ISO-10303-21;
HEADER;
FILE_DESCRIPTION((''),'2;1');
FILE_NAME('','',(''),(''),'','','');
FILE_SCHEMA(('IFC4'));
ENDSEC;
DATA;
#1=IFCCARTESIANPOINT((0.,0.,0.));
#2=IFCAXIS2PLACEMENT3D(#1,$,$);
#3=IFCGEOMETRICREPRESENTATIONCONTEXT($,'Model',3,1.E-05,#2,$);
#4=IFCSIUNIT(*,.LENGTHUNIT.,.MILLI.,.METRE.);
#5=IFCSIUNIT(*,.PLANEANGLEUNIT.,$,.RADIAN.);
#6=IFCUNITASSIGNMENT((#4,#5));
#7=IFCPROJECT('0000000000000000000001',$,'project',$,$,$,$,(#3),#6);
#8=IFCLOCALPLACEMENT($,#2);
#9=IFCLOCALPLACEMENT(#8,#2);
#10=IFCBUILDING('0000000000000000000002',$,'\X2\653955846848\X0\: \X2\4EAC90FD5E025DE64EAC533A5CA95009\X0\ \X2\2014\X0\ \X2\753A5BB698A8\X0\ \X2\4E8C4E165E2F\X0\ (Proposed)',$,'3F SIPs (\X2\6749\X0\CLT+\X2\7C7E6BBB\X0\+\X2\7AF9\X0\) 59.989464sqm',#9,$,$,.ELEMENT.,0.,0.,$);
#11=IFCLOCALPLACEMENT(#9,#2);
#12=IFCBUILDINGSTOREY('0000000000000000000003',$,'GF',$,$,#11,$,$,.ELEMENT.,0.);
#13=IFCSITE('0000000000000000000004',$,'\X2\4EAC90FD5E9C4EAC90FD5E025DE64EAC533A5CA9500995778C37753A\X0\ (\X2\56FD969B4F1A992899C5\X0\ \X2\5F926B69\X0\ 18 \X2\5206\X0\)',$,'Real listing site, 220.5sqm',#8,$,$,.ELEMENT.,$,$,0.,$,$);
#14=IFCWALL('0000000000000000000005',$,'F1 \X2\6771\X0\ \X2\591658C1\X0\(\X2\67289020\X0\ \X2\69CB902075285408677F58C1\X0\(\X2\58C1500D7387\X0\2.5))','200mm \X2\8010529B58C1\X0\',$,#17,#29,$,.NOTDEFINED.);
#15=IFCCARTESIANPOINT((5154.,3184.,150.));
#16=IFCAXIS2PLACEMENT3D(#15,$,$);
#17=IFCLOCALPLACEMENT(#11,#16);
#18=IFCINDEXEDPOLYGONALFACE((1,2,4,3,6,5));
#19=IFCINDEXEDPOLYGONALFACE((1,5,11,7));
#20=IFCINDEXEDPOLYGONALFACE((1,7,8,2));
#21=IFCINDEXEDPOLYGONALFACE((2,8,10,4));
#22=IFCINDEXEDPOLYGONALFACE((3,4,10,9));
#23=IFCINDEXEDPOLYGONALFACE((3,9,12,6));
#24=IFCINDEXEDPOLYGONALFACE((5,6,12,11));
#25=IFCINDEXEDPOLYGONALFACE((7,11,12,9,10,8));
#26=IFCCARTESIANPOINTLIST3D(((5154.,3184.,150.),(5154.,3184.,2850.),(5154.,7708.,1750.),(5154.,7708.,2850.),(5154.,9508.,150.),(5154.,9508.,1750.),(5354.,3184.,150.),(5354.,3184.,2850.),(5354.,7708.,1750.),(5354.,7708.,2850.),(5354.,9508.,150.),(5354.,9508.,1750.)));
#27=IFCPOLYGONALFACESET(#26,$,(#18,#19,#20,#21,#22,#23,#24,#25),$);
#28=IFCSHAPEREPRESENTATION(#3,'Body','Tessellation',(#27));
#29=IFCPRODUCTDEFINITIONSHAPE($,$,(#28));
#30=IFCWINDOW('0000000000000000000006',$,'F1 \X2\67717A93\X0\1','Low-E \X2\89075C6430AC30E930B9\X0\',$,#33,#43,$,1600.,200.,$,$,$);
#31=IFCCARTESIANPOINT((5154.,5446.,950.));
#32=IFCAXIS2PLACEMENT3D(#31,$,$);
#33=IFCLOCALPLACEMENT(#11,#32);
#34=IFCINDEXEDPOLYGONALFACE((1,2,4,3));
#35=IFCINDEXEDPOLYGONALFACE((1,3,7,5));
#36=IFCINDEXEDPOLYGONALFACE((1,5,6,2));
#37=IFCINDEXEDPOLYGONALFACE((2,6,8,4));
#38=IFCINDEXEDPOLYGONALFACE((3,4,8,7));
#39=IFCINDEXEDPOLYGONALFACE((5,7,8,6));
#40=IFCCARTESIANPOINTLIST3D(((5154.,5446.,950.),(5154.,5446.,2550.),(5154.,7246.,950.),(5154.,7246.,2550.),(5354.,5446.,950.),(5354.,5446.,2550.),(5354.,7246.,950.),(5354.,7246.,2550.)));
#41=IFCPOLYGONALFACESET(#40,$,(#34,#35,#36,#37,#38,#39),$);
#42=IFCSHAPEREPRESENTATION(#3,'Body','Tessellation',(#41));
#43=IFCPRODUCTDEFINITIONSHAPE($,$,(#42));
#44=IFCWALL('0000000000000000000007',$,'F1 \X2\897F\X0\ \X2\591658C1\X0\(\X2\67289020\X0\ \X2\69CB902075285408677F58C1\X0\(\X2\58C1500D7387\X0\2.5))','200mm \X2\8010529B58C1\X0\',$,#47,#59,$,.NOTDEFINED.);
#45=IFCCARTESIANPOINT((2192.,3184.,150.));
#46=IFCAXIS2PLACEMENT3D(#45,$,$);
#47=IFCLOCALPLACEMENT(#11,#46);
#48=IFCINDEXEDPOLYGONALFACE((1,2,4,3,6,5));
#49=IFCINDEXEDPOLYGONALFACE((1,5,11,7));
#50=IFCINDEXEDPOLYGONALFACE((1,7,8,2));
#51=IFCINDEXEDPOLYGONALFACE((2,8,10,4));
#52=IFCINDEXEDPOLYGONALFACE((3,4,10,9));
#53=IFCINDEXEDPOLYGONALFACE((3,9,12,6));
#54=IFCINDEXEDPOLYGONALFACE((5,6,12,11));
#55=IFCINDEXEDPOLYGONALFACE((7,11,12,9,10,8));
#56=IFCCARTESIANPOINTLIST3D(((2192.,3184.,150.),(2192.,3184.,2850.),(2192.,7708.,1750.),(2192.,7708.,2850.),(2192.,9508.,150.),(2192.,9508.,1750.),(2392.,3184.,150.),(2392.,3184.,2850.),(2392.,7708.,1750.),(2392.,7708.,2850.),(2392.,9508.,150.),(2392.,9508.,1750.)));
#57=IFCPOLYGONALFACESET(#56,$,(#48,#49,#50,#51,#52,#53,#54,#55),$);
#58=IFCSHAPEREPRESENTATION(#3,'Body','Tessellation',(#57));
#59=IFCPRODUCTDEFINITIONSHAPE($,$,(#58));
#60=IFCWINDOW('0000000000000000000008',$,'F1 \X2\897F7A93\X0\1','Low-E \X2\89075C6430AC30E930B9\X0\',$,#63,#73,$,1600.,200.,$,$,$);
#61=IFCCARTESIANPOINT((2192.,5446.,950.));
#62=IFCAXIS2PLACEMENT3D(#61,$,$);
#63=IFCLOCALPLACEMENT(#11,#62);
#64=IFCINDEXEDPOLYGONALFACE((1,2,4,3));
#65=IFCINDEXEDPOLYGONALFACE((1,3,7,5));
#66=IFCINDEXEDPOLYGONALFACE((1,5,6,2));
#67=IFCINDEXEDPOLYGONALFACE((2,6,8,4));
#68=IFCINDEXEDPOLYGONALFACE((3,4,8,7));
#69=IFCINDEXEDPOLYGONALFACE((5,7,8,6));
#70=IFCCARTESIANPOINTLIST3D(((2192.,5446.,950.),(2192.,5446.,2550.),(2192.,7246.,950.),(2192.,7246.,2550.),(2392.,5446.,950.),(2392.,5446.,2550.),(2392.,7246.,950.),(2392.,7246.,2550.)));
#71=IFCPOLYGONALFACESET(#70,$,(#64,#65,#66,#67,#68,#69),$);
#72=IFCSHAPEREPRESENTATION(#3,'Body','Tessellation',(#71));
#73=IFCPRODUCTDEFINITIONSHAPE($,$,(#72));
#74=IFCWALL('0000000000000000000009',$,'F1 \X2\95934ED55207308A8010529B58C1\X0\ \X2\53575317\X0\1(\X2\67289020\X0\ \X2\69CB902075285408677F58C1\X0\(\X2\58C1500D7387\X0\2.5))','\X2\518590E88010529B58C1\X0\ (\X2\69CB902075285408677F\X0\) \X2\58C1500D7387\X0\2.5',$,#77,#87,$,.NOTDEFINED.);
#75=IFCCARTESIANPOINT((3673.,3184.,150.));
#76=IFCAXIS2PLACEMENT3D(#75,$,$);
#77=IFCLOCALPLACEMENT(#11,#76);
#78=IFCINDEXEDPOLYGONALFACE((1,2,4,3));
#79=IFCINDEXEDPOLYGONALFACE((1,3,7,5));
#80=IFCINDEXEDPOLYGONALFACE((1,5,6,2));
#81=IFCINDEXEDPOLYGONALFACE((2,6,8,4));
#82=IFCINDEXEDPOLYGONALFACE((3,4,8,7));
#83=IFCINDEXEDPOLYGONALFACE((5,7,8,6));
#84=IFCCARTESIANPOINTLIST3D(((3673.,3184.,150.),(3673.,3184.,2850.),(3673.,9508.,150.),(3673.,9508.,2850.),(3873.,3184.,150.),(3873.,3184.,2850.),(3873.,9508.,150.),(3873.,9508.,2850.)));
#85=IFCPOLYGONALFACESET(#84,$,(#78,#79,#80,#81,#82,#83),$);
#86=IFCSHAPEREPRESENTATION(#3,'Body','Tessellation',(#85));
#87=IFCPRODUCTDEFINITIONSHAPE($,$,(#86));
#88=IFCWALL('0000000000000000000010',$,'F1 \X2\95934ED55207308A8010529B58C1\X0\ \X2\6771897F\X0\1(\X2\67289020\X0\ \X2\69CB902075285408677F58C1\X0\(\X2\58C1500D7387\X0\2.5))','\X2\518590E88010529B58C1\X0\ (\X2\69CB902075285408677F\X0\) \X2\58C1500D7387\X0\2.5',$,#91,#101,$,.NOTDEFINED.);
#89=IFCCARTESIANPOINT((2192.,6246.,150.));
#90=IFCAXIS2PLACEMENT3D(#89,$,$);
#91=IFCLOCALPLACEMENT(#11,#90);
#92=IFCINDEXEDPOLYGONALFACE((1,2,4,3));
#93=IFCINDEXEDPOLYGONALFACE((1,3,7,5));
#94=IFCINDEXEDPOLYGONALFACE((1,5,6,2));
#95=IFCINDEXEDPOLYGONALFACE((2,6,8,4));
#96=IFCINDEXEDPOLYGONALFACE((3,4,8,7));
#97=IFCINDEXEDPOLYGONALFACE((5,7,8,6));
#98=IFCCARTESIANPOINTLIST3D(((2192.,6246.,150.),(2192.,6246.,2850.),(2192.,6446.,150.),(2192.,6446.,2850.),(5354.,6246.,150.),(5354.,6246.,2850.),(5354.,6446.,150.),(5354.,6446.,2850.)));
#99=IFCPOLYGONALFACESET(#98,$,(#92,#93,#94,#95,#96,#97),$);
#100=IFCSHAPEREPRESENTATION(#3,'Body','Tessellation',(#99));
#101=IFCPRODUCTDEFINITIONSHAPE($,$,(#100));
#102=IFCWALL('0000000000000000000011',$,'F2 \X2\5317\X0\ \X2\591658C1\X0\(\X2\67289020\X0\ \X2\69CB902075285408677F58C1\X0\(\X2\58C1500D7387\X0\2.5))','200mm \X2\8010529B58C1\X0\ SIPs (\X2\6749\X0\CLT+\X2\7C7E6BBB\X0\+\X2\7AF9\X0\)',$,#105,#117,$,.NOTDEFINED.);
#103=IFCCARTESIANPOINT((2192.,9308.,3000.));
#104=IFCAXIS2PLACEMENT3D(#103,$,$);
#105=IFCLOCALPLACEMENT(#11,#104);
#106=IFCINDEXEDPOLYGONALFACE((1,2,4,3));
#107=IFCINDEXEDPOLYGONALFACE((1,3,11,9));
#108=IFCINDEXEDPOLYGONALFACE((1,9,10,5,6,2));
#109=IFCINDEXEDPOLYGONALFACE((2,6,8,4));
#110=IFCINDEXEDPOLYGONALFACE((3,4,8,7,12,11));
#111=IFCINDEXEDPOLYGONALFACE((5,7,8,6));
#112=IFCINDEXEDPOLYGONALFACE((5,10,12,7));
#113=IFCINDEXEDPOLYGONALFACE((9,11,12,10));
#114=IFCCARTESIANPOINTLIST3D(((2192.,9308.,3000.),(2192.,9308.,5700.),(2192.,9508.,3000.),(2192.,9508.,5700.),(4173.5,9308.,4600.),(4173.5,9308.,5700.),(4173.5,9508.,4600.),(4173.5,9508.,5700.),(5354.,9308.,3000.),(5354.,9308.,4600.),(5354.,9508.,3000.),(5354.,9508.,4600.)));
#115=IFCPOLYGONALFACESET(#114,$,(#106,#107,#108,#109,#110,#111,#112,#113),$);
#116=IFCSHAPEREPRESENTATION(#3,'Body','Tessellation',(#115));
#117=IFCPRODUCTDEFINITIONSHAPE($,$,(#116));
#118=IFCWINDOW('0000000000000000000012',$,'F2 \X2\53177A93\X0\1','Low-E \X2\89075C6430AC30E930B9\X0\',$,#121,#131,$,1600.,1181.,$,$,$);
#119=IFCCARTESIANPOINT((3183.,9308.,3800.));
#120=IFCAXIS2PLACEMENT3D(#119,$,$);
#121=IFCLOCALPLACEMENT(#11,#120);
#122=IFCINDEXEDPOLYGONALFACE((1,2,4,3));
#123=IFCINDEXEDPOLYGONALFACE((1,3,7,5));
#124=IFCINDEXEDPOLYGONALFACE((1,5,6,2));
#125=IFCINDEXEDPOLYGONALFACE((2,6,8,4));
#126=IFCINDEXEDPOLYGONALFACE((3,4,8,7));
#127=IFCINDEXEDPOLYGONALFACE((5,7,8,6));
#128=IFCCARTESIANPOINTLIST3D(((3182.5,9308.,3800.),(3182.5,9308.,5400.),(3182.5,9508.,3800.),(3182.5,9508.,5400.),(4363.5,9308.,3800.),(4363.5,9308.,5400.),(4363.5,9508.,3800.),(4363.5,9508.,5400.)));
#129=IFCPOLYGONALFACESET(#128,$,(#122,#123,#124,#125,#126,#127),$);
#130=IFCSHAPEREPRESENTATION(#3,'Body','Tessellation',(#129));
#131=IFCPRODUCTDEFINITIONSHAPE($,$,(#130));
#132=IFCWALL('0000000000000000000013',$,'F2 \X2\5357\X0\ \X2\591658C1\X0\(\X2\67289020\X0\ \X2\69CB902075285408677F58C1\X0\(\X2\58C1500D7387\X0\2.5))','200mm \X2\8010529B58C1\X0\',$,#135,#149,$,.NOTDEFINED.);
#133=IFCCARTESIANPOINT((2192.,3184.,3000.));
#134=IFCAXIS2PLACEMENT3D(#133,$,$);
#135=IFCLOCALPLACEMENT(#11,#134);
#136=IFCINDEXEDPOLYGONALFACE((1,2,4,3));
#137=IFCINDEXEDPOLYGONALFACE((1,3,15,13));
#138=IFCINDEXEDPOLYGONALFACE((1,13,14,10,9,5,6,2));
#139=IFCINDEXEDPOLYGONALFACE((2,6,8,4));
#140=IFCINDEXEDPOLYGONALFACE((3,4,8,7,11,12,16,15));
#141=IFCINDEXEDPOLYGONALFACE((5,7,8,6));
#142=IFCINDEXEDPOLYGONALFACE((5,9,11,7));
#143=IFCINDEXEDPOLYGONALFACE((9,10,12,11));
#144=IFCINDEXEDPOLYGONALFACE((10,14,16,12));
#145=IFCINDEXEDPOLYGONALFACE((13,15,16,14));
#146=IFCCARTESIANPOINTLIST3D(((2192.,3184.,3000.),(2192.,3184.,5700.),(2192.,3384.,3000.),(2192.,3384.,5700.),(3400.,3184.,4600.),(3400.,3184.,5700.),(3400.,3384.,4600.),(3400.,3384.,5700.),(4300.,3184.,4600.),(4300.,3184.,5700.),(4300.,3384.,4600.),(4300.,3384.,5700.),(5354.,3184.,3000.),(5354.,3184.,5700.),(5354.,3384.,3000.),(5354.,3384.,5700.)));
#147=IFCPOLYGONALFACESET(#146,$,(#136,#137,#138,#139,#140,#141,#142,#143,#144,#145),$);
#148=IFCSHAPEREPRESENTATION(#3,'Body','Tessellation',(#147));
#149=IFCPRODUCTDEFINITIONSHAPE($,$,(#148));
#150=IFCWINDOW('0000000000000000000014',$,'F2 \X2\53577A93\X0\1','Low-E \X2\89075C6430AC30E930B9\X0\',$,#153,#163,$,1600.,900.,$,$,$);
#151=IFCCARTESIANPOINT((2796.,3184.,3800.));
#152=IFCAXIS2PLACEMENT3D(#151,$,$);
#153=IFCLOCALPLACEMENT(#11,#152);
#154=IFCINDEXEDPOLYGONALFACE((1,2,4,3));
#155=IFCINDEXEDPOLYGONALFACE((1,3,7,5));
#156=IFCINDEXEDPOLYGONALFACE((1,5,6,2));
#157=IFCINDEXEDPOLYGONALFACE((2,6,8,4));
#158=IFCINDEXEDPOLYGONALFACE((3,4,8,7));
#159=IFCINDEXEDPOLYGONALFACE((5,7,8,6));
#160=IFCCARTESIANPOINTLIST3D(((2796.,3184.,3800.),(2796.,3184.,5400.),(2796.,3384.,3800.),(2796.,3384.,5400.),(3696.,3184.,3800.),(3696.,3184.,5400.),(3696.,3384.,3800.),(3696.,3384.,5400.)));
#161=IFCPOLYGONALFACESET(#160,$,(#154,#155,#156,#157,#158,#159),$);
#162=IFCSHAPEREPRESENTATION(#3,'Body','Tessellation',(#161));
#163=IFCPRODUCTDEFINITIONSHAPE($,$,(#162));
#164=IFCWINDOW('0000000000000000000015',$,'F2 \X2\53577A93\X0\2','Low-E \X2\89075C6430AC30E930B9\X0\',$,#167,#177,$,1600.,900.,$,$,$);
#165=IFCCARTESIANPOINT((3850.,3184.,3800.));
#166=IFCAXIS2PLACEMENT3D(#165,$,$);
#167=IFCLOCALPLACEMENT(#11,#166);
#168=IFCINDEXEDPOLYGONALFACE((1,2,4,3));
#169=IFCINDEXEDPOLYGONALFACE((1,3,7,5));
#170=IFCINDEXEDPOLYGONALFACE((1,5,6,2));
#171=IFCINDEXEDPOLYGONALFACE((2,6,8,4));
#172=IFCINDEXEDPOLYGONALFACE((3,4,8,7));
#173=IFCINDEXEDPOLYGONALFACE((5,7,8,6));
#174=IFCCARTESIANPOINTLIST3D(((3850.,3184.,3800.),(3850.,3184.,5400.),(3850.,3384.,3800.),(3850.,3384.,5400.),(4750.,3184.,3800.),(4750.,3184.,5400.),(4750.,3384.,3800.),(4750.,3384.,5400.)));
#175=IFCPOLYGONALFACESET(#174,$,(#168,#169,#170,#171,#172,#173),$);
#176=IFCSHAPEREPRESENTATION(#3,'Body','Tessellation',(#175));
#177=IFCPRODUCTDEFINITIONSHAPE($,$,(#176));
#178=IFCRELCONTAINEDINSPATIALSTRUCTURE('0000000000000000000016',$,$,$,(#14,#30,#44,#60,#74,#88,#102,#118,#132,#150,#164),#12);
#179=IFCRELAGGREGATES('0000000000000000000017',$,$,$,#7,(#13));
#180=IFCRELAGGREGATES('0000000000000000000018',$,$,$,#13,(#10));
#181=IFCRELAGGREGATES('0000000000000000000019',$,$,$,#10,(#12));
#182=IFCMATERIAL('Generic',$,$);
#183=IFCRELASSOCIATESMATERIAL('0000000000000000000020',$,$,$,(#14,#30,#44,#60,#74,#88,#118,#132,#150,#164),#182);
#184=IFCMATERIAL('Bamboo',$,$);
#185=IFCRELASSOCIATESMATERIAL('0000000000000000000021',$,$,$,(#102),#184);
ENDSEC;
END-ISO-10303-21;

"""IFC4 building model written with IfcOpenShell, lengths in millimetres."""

from ifc_helpers import new_model, si_unit, frame, frame_2d, origin, place, context, project, spatial, rectangle, extrude, material, element, fill, save


model = new_model("IFC4")

# Units and contexts
model_context = context("Model", 3, precision=1e-05, world=origin())
ifc_project = project(units=[si_unit("LENGTHUNIT", "METRE", prefix="MILLI"), si_unit("PLANEANGLEUNIT", "RADIAN")], contexts=[model_context])

# Site, building, storey
site_placement = place(None, origin())
site = spatial("IfcSite", under=ifc_project, at=site_placement, Name="京都府京都市左京区岩倉長谷町 (国際会館駅 徒歩 18 分)", ObjectType="Real listing site, 220.5sqm", CompositionType="ELEMENT", RefElevation=0.0)
building_placement = place(site_placement, origin())
building = spatial("IfcBuilding", under=site, at=building_placement, Name="改善案: 京都市左京区岩倉 — 町家風 二世帯 (Proposed)", ObjectType="3F SIPs (杉CLT+籾殻+竹) 59.989464sqm", CompositionType="ELEMENT", ElevationOfRefHeight=0.0, ElevationOfTerrain=0.0)
storey_placement = place(building_placement, origin())
storey = spatial("IfcBuildingStorey", under=building, at=storey_placement, Name="GF", CompositionType="ELEMENT", Elevation=0.0)

# Shared definitions
ifc_material_1 = material(Name="Generic")

# Shared definitions
ifc_material_2 = material(Name="Bamboo")

# Walls, openings, windows
wall_1_placement = place(storey_placement, frame((5154.0, 3184.0, 150.0)))
wall_1 = element("IfcWall", 1, at=wall_1_placement, inside=storey, material=ifc_material_1, Name="F1 東 外壁(木造 構造用合板壁(壁倍率2.5))", Description="200mm 耐力壁", PredefinedType="NOTDEFINED", context=model_context, shape_type="SweptSolid", body=[
    extrude(rectangle(XDim=200.0, YDim=6324.0, at=frame_2d((100.0, 3162.0))), frame((5154.0, 3184.0, 150.0)), (0.0, 0.0, 1.0), 2700.0),
])
opening_1_placement = place(storey_placement, frame((5154.0, 5446.0, 950.0)))
opening_1 = element("IfcOpeningElement", 2, at=opening_1_placement, cuts=wall_1, PredefinedType="NOTDEFINED", context=model_context, shape_type="SweptSolid", body=[
    extrude(rectangle(XDim=200.0, YDim=1800.0, at=frame_2d((100.0, 900.0))), frame((5154.0, 5446.0, 950.0)), (0.0, 0.0, 1.0), 1600.0),
])
window_1_placement = place(storey_placement, frame((5154.0, 5446.0, 950.0)))
window_1 = element("IfcWindow", 3, at=window_1_placement, inside=storey, material=ifc_material_1, Name="F1 東窓1", Description="Low-E 複層ガラス", OverallHeight=1600.0, OverallWidth=200.0, context=model_context, shape_type="SweptSolid", body=[
    extrude(rectangle(XDim=200.0, YDim=1800.0, at=frame_2d((100.0, 900.0))), frame((5154.0, 5446.0, 950.0)), (0.0, 0.0, 1.0), 1600.0),
])
fill(opening_1, window_1)
wall_2_placement = place(storey_placement, frame((2192.0, 3184.0, 150.0)))
wall_2 = element("IfcWall", 4, at=wall_2_placement, inside=storey, material=ifc_material_1, Name="F1 西 外壁(木造 構造用合板壁(壁倍率2.5))", Description="200mm 耐力壁", PredefinedType="NOTDEFINED", context=model_context, shape_type="SweptSolid", body=[
    extrude(rectangle(XDim=200.0, YDim=6324.0, at=frame_2d((100.0, 3162.0))), frame((2192.0, 3184.0, 150.0)), (0.0, 0.0, 1.0), 2700.0),
])
opening_2_placement = place(storey_placement, frame((2192.0, 5446.0, 950.0)))
opening_2 = element("IfcOpeningElement", 5, at=opening_2_placement, cuts=wall_2, PredefinedType="NOTDEFINED", context=model_context, shape_type="SweptSolid", body=[
    extrude(rectangle(XDim=200.0, YDim=1800.0, at=frame_2d((100.0, 900.0))), frame((2192.0, 5446.0, 950.0)), (0.0, 0.0, 1.0), 1600.0),
])
window_2_placement = place(storey_placement, frame((2192.0, 5446.0, 950.0)))
window_2 = element("IfcWindow", 6, at=window_2_placement, inside=storey, material=ifc_material_1, Name="F1 西窓1", Description="Low-E 複層ガラス", OverallHeight=1600.0, OverallWidth=200.0, context=model_context, shape_type="SweptSolid", body=[
    extrude(rectangle(XDim=200.0, YDim=1800.0, at=frame_2d((100.0, 900.0))), frame((2192.0, 5446.0, 950.0)), (0.0, 0.0, 1.0), 1600.0),
])
fill(opening_2, window_2)

# Walls
wall_3_placement = place(storey_placement, frame((3673.0, 3184.0, 150.0)))
element("IfcWall", 7, at=wall_3_placement, inside=storey, material=ifc_material_1, Name="F1 間仕切り耐力壁 南北1(木造 構造用合板壁(壁倍率2.5))", Description="内部耐力壁 (構造用合板) 壁倍率2.5", PredefinedType="NOTDEFINED", context=model_context, shape_type="SweptSolid", body=[
    extrude(rectangle(XDim=200.0, YDim=6324.0, at=frame_2d((100.0, 3162.0))), frame((3673.0, 3184.0, 150.0)), (0.0, 0.0, 1.0), 2700.0),
])
wall_4_placement = place(storey_placement, frame((2192.0, 6246.0, 150.0)))
element("IfcWall", 8, at=wall_4_placement, inside=storey, material=ifc_material_1, Name="F1 間仕切り耐力壁 東西1(木造 構造用合板壁(壁倍率2.5))", Description="内部耐力壁 (構造用合板) 壁倍率2.5", PredefinedType="NOTDEFINED", context=model_context, shape_type="SweptSolid", body=[
    extrude(rectangle(XDim=3162.0, YDim=200.0, at=frame_2d((1581.0, 100.0))), frame((2192.0, 6246.0, 150.0)), (0.0, 0.0, 1.0), 2700.0),
])

# Wall, opening, window
wall_5_placement = place(storey_placement, frame((2192.0, 9308.0, 3000.0)))
wall_5 = element("IfcWall", 9, at=wall_5_placement, inside=storey, material=ifc_material_2, Name="F2 北 外壁(木造 構造用合板壁(壁倍率2.5))", Description="200mm 耐力壁 SIPs (杉CLT+籾殻+竹)", PredefinedType="NOTDEFINED", context=model_context, shape_type="SweptSolid", body=[
    extrude(rectangle(XDim=3162.0, YDim=200.0, at=frame_2d((1581.0, 100.0))), frame((2192.0, 9308.0, 3000.0)), (0.0, 0.0, 1.0), 2700.0),
])
opening_3_placement = place(storey_placement, frame((3183.0, 9308.0, 3800.0)))
opening_3 = element("IfcOpeningElement", 10, at=opening_3_placement, cuts=wall_5, PredefinedType="NOTDEFINED", context=model_context, shape_type="SweptSolid", body=[
    extrude(rectangle(XDim=1181.0, YDim=200.0, at=frame_2d((590.0, 100.0))), frame((3183.0, 9308.0, 3800.0)), (0.0, 0.0, 1.0), 1600.0),
])
window_3_placement = place(storey_placement, frame((3183.0, 9308.0, 3800.0)))
window_3 = element("IfcWindow", 11, at=window_3_placement, inside=storey, material=ifc_material_1, Name="F2 北窓1", Description="Low-E 複層ガラス", OverallHeight=1600.0, OverallWidth=1181.0, context=model_context, shape_type="SweptSolid", body=[
    extrude(rectangle(XDim=1181.0, YDim=200.0, at=frame_2d((590.0, 100.0))), frame((3183.0, 9308.0, 3800.0)), (0.0, 0.0, 1.0), 1600.0),
])
fill(opening_3, window_3)

# Wall, openings, windows
wall_6_placement = place(storey_placement, frame((2192.0, 3184.0, 3000.0)))
wall_6 = element("IfcWall", 12, at=wall_6_placement, inside=storey, material=ifc_material_1, Name="F2 南 外壁(木造 構造用合板壁(壁倍率2.5))", Description="200mm 耐力壁", PredefinedType="NOTDEFINED", context=model_context, shape_type="SweptSolid", body=[
    extrude(rectangle(XDim=3162.0, YDim=200.0, at=frame_2d((1581.0, 100.0))), frame((2192.0, 3184.0, 3000.0)), (0.0, 0.0, 1.0), 2700.0),
])
opening_4_placement = place(storey_placement, frame((2796.0, 3184.0, 3800.0)))
opening_4 = element("IfcOpeningElement", 13, at=opening_4_placement, cuts=wall_6, PredefinedType="NOTDEFINED", context=model_context, shape_type="SweptSolid", body=[
    extrude(rectangle(XDim=900.0, YDim=200.0, at=frame_2d((450.0, 100.0))), frame((2796.0, 3184.0, 3800.0)), (0.0, 0.0, 1.0), 1600.0),
])
opening_5_placement = place(storey_placement, frame((3850.0, 3184.0, 3800.0)))
opening_5 = element("IfcOpeningElement", 14, at=opening_5_placement, cuts=wall_6, PredefinedType="NOTDEFINED", context=model_context, shape_type="SweptSolid", body=[
    extrude(rectangle(XDim=900.0, YDim=200.0, at=frame_2d((450.0, 100.0))), frame((3850.0, 3184.0, 3800.0)), (0.0, 0.0, 1.0), 1600.0),
])
window_4_placement = place(storey_placement, frame((2796.0, 3184.0, 3800.0)))
window_4 = element("IfcWindow", 15, at=window_4_placement, inside=storey, material=ifc_material_1, Name="F2 南窓1", Description="Low-E 複層ガラス", OverallHeight=1600.0, OverallWidth=900.0, context=model_context, shape_type="SweptSolid", body=[
    extrude(rectangle(XDim=900.0, YDim=200.0, at=frame_2d((450.0, 100.0))), frame((2796.0, 3184.0, 3800.0)), (0.0, 0.0, 1.0), 1600.0),
])
fill(opening_4, window_4)
window_5_placement = place(storey_placement, frame((3850.0, 3184.0, 3800.0)))
window_5 = element("IfcWindow", 16, at=window_5_placement, inside=storey, material=ifc_material_1, Name="F2 南窓2", Description="Low-E 複層ガラス", OverallHeight=1600.0, OverallWidth=900.0, context=model_context, shape_type="SweptSolid", body=[
    extrude(rectangle(XDim=900.0, YDim=200.0, at=frame_2d((450.0, 100.0))), frame((3850.0, 3184.0, 3800.0)), (0.0, 0.0, 1.0), 1600.0),
])
fill(opening_5, window_5)

save(model, "model.ifc")
